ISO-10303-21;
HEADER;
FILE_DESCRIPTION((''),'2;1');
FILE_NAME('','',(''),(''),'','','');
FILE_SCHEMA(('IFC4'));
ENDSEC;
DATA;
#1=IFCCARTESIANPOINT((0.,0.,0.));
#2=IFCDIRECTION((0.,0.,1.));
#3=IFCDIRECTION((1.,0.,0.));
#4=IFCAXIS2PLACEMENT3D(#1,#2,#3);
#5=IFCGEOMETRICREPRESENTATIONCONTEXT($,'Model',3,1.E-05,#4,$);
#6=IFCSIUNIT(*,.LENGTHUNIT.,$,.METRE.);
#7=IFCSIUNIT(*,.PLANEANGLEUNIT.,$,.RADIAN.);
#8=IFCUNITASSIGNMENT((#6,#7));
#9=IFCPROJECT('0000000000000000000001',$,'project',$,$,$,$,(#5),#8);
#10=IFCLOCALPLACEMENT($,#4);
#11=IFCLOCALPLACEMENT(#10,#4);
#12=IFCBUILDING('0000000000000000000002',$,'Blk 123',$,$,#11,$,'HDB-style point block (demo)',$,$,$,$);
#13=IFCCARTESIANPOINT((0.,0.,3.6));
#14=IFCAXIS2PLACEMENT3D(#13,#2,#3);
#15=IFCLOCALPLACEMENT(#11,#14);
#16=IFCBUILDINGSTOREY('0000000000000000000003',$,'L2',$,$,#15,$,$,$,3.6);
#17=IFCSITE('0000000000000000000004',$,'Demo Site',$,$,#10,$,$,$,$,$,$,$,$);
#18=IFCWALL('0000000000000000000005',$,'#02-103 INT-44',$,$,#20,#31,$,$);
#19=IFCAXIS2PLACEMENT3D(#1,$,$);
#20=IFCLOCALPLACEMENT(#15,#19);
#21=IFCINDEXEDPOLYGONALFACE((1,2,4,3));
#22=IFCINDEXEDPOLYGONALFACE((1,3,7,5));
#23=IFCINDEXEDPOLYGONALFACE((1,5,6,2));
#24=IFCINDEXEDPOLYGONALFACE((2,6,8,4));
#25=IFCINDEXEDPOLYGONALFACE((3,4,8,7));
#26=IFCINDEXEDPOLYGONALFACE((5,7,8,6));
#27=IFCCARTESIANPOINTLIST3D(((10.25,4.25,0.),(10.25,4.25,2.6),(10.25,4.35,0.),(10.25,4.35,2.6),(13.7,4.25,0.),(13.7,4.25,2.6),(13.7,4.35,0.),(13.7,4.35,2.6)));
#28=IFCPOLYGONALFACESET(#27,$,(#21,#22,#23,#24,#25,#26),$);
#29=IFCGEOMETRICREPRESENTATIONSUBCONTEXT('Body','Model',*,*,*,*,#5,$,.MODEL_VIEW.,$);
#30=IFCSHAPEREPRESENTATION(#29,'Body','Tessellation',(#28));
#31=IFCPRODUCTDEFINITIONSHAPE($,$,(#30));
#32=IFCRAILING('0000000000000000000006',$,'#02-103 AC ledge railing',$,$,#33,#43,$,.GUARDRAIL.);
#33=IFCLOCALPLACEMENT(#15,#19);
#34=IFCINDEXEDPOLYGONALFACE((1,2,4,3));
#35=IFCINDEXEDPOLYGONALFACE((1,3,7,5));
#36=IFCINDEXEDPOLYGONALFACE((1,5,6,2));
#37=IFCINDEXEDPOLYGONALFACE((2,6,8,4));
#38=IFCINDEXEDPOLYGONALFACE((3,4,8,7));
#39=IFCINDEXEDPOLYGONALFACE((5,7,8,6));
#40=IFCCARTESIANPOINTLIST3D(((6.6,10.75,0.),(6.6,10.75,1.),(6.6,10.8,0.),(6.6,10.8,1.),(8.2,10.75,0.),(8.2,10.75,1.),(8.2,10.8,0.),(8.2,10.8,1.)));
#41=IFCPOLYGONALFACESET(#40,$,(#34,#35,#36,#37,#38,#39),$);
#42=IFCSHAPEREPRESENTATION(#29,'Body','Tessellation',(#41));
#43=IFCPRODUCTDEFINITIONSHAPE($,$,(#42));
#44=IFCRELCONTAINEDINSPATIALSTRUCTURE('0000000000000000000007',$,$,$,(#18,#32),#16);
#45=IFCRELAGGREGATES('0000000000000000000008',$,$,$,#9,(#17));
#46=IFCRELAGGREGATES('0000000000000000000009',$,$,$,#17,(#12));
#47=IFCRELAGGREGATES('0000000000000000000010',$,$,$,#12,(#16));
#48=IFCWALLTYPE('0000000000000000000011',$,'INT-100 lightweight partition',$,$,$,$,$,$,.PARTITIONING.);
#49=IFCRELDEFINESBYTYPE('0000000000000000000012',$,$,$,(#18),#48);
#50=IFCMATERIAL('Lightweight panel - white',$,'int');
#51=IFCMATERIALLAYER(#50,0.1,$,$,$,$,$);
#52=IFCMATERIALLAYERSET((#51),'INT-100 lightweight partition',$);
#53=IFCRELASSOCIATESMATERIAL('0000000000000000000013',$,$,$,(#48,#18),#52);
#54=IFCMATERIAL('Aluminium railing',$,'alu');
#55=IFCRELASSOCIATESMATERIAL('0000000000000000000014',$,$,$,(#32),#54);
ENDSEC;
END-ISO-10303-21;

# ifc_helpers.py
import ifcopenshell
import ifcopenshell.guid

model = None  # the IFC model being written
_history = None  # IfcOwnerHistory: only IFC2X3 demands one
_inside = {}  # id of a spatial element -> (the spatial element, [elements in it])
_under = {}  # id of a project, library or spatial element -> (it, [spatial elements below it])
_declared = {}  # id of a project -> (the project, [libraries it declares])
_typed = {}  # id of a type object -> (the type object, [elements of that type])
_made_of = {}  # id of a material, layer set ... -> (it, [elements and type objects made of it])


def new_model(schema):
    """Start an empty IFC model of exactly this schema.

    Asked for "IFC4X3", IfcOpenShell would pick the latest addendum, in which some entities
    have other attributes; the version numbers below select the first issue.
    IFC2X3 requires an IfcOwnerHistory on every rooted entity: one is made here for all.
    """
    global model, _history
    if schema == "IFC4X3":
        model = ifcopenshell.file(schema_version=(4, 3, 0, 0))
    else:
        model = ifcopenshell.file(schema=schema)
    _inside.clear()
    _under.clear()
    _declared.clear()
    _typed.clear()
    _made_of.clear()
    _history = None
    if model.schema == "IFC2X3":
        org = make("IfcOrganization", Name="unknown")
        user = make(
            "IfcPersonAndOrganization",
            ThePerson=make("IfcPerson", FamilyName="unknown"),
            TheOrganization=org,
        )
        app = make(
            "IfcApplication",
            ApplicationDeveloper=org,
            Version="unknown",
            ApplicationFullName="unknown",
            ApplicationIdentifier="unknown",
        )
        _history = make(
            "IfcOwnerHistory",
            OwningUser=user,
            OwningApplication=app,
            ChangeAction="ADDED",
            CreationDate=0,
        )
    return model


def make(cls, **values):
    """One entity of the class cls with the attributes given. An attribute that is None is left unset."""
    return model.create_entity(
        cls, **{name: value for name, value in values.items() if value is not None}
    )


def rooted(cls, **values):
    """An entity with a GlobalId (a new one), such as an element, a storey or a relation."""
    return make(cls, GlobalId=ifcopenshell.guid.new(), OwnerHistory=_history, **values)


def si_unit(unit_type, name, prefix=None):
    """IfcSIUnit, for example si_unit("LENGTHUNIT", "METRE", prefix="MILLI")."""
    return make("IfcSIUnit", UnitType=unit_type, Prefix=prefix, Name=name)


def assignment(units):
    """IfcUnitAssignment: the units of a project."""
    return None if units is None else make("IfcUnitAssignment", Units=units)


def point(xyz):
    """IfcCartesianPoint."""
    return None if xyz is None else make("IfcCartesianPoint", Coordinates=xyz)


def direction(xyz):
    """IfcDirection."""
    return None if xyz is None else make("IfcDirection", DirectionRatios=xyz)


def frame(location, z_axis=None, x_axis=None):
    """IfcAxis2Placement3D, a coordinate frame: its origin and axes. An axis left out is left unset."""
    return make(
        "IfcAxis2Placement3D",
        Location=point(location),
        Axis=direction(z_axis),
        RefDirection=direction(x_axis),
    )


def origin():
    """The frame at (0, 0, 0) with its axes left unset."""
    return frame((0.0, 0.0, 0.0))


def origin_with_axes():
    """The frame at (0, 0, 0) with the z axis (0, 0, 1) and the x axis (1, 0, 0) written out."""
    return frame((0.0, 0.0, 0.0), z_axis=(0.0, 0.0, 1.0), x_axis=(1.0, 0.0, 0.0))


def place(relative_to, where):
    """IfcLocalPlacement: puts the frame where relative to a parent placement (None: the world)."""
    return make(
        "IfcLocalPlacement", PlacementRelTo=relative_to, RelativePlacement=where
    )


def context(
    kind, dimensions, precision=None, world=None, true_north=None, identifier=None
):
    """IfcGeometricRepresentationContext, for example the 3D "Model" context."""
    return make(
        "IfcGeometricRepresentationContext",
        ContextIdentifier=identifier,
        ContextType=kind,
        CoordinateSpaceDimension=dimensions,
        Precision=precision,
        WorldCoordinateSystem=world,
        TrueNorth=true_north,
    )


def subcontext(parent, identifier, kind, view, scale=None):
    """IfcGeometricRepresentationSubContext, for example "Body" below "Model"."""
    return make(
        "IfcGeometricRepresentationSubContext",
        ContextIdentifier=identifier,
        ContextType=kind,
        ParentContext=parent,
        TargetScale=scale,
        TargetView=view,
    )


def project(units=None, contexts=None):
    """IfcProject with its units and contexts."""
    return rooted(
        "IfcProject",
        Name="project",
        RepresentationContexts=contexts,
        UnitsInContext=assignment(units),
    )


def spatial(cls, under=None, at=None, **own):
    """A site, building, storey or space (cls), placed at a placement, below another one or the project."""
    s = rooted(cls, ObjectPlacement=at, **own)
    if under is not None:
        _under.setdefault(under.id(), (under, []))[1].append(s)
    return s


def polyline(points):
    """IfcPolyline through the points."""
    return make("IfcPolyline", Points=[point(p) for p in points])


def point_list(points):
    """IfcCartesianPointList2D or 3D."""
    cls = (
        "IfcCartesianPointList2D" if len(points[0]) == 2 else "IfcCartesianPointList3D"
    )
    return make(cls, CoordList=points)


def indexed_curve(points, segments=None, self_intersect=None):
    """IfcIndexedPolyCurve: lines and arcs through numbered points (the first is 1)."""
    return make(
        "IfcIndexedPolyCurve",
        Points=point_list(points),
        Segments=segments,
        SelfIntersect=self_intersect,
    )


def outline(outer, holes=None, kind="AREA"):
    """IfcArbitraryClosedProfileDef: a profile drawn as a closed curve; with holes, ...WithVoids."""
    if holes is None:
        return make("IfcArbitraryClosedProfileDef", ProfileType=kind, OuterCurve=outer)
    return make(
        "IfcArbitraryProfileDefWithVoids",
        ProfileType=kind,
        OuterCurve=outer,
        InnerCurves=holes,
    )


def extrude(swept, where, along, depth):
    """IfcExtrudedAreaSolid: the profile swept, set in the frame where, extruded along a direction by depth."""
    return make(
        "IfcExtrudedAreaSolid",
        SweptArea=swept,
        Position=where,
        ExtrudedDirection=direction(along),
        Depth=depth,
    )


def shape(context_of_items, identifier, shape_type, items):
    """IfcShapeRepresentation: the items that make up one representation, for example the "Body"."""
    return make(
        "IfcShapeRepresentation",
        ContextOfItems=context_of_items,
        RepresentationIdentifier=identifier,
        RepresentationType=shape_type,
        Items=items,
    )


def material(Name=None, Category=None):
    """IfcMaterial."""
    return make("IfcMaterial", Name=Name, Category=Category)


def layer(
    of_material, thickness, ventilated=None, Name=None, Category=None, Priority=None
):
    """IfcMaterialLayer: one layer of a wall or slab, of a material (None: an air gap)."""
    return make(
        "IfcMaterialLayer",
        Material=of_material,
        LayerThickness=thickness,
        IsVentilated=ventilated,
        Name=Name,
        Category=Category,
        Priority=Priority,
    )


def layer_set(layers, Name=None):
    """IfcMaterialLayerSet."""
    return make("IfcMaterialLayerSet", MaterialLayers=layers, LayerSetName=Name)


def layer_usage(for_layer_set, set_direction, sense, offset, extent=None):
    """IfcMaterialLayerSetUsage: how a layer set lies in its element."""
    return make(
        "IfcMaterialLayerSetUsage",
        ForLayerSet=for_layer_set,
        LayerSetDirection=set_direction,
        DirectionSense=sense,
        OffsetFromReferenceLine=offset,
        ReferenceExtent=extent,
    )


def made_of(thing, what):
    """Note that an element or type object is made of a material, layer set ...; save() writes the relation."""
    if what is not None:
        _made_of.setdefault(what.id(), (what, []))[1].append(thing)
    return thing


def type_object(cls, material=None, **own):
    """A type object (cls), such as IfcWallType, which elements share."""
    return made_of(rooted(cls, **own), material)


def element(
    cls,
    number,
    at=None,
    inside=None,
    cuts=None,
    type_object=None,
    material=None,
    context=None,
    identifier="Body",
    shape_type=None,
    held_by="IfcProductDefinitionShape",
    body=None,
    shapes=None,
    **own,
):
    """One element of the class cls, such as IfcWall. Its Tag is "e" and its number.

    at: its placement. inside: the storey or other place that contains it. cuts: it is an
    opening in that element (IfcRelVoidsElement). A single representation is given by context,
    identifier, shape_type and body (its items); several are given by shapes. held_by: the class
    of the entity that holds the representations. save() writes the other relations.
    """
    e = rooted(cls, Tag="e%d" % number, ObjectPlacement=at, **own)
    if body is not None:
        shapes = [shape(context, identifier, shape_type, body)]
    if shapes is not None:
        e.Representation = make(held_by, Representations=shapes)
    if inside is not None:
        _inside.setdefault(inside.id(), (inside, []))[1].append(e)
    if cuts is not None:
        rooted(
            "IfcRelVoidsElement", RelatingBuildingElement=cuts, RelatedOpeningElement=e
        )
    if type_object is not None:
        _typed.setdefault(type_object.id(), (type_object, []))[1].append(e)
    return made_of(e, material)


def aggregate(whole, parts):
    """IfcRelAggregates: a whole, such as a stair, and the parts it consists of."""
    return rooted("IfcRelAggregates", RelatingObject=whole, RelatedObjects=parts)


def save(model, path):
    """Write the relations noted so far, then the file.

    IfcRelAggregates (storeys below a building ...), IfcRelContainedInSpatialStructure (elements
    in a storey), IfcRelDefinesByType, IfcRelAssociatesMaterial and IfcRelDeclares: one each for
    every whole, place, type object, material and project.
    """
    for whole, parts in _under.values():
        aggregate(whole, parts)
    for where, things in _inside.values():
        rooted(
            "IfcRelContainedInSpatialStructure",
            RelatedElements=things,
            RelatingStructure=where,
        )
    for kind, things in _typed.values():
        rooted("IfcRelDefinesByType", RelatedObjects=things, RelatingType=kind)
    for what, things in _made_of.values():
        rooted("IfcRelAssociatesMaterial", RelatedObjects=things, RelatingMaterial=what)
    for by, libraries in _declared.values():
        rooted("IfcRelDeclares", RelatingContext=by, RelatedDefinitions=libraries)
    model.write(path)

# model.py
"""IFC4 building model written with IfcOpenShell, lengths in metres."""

from ifc_helpers import new_model, si_unit, frame, origin, origin_with_axes, place, context, subcontext, project, spatial, polyline, indexed_curve, outline, extrude, material, layer, layer_set, layer_usage, type_object, element, save


model = new_model("IFC4")

# Units and contexts
model_context = context("Model", 3, precision=1e-05, world=origin_with_axes())
body_context = subcontext(model_context, "Body", "Model", "MODEL_VIEW")
ifc_project = project(units=[si_unit("LENGTHUNIT", "METRE"), si_unit("PLANEANGLEUNIT", "RADIAN")], contexts=[model_context])

# Site, building, storey
site_placement = place(None, origin_with_axes())
site = spatial("IfcSite", under=ifc_project, at=site_placement, Name="Demo Site")
building_placement = place(site_placement, origin_with_axes())
building = spatial("IfcBuilding", under=site, at=building_placement, Name="Blk 123", LongName="HDB-style point block (demo)")
storey_placement = place(building_placement, frame((0.0, 0.0, 3.6), z_axis=(0.0, 0.0, 1.0), x_axis=(1.0, 0.0, 0.0)))
storey = spatial("IfcBuildingStorey", under=building, at=storey_placement, Name="L2", Elevation=3.6)

# Wall
ifc_material_1 = material(Name="Lightweight panel - white", Category="int")
ifc_layer_1 = layer(ifc_material_1, 0.1)
ifc_layer_set_1 = layer_set([ifc_layer_1], Name="INT-100 lightweight partition")
ifc_layer_usage_1 = layer_usage(ifc_layer_set_1, "AXIS2", "POSITIVE", -0.05)
wall_type_1 = type_object("IfcWallType", Name="INT-100 lightweight partition", PredefinedType="PARTITIONING", material=ifc_layer_set_1)
wall_1_placement = place(storey_placement, frame((10.25, 4.3, 0.0), z_axis=(0.0, 0.0, 1.0), x_axis=(1.0, 0.0, 0.0)))
element("IfcWall", 1, at=wall_1_placement, inside=storey, type_object=wall_type_1, material=ifc_layer_usage_1, Name="#02-103 INT-44", context=body_context, shape_type="SweptSolid", body=[
    extrude(outline(indexed_curve([(0.0, 0.0), (0.0, 0.1), (3.45, 0.1), (3.45, 0.0), (0.0, 0.0)], self_intersect=False)), frame((0.0, -0.05, 0.0), z_axis=(0.0, 0.0, 1.0), x_axis=(1.0, 0.0, 0.0)), (0.0, 0.0, 1.0), 2.6),
])

# Railing
ifc_material_2 = material(Name="Aluminium railing", Category="alu")
railing_placement = place(storey_placement, frame((7.4, 10.775, 0.0), z_axis=(0.0, 0.0, 1.0), x_axis=(1.0, 0.0, 0.0)))
element("IfcRailing", 2, at=railing_placement, inside=storey, material=ifc_material_2, Name="#02-103 AC ledge railing", PredefinedType="GUARDRAIL", context=body_context, shape_type="SweptSolid", body=[
    extrude(outline(polyline([(0.8, -0.025), (0.8, 0.025), (-0.8, 0.025), (-0.8, -0.025), (0.8, -0.025)])), origin(), (0.0, 0.0, 1.0), 1.0),
])

save(model, "model.ifc")
